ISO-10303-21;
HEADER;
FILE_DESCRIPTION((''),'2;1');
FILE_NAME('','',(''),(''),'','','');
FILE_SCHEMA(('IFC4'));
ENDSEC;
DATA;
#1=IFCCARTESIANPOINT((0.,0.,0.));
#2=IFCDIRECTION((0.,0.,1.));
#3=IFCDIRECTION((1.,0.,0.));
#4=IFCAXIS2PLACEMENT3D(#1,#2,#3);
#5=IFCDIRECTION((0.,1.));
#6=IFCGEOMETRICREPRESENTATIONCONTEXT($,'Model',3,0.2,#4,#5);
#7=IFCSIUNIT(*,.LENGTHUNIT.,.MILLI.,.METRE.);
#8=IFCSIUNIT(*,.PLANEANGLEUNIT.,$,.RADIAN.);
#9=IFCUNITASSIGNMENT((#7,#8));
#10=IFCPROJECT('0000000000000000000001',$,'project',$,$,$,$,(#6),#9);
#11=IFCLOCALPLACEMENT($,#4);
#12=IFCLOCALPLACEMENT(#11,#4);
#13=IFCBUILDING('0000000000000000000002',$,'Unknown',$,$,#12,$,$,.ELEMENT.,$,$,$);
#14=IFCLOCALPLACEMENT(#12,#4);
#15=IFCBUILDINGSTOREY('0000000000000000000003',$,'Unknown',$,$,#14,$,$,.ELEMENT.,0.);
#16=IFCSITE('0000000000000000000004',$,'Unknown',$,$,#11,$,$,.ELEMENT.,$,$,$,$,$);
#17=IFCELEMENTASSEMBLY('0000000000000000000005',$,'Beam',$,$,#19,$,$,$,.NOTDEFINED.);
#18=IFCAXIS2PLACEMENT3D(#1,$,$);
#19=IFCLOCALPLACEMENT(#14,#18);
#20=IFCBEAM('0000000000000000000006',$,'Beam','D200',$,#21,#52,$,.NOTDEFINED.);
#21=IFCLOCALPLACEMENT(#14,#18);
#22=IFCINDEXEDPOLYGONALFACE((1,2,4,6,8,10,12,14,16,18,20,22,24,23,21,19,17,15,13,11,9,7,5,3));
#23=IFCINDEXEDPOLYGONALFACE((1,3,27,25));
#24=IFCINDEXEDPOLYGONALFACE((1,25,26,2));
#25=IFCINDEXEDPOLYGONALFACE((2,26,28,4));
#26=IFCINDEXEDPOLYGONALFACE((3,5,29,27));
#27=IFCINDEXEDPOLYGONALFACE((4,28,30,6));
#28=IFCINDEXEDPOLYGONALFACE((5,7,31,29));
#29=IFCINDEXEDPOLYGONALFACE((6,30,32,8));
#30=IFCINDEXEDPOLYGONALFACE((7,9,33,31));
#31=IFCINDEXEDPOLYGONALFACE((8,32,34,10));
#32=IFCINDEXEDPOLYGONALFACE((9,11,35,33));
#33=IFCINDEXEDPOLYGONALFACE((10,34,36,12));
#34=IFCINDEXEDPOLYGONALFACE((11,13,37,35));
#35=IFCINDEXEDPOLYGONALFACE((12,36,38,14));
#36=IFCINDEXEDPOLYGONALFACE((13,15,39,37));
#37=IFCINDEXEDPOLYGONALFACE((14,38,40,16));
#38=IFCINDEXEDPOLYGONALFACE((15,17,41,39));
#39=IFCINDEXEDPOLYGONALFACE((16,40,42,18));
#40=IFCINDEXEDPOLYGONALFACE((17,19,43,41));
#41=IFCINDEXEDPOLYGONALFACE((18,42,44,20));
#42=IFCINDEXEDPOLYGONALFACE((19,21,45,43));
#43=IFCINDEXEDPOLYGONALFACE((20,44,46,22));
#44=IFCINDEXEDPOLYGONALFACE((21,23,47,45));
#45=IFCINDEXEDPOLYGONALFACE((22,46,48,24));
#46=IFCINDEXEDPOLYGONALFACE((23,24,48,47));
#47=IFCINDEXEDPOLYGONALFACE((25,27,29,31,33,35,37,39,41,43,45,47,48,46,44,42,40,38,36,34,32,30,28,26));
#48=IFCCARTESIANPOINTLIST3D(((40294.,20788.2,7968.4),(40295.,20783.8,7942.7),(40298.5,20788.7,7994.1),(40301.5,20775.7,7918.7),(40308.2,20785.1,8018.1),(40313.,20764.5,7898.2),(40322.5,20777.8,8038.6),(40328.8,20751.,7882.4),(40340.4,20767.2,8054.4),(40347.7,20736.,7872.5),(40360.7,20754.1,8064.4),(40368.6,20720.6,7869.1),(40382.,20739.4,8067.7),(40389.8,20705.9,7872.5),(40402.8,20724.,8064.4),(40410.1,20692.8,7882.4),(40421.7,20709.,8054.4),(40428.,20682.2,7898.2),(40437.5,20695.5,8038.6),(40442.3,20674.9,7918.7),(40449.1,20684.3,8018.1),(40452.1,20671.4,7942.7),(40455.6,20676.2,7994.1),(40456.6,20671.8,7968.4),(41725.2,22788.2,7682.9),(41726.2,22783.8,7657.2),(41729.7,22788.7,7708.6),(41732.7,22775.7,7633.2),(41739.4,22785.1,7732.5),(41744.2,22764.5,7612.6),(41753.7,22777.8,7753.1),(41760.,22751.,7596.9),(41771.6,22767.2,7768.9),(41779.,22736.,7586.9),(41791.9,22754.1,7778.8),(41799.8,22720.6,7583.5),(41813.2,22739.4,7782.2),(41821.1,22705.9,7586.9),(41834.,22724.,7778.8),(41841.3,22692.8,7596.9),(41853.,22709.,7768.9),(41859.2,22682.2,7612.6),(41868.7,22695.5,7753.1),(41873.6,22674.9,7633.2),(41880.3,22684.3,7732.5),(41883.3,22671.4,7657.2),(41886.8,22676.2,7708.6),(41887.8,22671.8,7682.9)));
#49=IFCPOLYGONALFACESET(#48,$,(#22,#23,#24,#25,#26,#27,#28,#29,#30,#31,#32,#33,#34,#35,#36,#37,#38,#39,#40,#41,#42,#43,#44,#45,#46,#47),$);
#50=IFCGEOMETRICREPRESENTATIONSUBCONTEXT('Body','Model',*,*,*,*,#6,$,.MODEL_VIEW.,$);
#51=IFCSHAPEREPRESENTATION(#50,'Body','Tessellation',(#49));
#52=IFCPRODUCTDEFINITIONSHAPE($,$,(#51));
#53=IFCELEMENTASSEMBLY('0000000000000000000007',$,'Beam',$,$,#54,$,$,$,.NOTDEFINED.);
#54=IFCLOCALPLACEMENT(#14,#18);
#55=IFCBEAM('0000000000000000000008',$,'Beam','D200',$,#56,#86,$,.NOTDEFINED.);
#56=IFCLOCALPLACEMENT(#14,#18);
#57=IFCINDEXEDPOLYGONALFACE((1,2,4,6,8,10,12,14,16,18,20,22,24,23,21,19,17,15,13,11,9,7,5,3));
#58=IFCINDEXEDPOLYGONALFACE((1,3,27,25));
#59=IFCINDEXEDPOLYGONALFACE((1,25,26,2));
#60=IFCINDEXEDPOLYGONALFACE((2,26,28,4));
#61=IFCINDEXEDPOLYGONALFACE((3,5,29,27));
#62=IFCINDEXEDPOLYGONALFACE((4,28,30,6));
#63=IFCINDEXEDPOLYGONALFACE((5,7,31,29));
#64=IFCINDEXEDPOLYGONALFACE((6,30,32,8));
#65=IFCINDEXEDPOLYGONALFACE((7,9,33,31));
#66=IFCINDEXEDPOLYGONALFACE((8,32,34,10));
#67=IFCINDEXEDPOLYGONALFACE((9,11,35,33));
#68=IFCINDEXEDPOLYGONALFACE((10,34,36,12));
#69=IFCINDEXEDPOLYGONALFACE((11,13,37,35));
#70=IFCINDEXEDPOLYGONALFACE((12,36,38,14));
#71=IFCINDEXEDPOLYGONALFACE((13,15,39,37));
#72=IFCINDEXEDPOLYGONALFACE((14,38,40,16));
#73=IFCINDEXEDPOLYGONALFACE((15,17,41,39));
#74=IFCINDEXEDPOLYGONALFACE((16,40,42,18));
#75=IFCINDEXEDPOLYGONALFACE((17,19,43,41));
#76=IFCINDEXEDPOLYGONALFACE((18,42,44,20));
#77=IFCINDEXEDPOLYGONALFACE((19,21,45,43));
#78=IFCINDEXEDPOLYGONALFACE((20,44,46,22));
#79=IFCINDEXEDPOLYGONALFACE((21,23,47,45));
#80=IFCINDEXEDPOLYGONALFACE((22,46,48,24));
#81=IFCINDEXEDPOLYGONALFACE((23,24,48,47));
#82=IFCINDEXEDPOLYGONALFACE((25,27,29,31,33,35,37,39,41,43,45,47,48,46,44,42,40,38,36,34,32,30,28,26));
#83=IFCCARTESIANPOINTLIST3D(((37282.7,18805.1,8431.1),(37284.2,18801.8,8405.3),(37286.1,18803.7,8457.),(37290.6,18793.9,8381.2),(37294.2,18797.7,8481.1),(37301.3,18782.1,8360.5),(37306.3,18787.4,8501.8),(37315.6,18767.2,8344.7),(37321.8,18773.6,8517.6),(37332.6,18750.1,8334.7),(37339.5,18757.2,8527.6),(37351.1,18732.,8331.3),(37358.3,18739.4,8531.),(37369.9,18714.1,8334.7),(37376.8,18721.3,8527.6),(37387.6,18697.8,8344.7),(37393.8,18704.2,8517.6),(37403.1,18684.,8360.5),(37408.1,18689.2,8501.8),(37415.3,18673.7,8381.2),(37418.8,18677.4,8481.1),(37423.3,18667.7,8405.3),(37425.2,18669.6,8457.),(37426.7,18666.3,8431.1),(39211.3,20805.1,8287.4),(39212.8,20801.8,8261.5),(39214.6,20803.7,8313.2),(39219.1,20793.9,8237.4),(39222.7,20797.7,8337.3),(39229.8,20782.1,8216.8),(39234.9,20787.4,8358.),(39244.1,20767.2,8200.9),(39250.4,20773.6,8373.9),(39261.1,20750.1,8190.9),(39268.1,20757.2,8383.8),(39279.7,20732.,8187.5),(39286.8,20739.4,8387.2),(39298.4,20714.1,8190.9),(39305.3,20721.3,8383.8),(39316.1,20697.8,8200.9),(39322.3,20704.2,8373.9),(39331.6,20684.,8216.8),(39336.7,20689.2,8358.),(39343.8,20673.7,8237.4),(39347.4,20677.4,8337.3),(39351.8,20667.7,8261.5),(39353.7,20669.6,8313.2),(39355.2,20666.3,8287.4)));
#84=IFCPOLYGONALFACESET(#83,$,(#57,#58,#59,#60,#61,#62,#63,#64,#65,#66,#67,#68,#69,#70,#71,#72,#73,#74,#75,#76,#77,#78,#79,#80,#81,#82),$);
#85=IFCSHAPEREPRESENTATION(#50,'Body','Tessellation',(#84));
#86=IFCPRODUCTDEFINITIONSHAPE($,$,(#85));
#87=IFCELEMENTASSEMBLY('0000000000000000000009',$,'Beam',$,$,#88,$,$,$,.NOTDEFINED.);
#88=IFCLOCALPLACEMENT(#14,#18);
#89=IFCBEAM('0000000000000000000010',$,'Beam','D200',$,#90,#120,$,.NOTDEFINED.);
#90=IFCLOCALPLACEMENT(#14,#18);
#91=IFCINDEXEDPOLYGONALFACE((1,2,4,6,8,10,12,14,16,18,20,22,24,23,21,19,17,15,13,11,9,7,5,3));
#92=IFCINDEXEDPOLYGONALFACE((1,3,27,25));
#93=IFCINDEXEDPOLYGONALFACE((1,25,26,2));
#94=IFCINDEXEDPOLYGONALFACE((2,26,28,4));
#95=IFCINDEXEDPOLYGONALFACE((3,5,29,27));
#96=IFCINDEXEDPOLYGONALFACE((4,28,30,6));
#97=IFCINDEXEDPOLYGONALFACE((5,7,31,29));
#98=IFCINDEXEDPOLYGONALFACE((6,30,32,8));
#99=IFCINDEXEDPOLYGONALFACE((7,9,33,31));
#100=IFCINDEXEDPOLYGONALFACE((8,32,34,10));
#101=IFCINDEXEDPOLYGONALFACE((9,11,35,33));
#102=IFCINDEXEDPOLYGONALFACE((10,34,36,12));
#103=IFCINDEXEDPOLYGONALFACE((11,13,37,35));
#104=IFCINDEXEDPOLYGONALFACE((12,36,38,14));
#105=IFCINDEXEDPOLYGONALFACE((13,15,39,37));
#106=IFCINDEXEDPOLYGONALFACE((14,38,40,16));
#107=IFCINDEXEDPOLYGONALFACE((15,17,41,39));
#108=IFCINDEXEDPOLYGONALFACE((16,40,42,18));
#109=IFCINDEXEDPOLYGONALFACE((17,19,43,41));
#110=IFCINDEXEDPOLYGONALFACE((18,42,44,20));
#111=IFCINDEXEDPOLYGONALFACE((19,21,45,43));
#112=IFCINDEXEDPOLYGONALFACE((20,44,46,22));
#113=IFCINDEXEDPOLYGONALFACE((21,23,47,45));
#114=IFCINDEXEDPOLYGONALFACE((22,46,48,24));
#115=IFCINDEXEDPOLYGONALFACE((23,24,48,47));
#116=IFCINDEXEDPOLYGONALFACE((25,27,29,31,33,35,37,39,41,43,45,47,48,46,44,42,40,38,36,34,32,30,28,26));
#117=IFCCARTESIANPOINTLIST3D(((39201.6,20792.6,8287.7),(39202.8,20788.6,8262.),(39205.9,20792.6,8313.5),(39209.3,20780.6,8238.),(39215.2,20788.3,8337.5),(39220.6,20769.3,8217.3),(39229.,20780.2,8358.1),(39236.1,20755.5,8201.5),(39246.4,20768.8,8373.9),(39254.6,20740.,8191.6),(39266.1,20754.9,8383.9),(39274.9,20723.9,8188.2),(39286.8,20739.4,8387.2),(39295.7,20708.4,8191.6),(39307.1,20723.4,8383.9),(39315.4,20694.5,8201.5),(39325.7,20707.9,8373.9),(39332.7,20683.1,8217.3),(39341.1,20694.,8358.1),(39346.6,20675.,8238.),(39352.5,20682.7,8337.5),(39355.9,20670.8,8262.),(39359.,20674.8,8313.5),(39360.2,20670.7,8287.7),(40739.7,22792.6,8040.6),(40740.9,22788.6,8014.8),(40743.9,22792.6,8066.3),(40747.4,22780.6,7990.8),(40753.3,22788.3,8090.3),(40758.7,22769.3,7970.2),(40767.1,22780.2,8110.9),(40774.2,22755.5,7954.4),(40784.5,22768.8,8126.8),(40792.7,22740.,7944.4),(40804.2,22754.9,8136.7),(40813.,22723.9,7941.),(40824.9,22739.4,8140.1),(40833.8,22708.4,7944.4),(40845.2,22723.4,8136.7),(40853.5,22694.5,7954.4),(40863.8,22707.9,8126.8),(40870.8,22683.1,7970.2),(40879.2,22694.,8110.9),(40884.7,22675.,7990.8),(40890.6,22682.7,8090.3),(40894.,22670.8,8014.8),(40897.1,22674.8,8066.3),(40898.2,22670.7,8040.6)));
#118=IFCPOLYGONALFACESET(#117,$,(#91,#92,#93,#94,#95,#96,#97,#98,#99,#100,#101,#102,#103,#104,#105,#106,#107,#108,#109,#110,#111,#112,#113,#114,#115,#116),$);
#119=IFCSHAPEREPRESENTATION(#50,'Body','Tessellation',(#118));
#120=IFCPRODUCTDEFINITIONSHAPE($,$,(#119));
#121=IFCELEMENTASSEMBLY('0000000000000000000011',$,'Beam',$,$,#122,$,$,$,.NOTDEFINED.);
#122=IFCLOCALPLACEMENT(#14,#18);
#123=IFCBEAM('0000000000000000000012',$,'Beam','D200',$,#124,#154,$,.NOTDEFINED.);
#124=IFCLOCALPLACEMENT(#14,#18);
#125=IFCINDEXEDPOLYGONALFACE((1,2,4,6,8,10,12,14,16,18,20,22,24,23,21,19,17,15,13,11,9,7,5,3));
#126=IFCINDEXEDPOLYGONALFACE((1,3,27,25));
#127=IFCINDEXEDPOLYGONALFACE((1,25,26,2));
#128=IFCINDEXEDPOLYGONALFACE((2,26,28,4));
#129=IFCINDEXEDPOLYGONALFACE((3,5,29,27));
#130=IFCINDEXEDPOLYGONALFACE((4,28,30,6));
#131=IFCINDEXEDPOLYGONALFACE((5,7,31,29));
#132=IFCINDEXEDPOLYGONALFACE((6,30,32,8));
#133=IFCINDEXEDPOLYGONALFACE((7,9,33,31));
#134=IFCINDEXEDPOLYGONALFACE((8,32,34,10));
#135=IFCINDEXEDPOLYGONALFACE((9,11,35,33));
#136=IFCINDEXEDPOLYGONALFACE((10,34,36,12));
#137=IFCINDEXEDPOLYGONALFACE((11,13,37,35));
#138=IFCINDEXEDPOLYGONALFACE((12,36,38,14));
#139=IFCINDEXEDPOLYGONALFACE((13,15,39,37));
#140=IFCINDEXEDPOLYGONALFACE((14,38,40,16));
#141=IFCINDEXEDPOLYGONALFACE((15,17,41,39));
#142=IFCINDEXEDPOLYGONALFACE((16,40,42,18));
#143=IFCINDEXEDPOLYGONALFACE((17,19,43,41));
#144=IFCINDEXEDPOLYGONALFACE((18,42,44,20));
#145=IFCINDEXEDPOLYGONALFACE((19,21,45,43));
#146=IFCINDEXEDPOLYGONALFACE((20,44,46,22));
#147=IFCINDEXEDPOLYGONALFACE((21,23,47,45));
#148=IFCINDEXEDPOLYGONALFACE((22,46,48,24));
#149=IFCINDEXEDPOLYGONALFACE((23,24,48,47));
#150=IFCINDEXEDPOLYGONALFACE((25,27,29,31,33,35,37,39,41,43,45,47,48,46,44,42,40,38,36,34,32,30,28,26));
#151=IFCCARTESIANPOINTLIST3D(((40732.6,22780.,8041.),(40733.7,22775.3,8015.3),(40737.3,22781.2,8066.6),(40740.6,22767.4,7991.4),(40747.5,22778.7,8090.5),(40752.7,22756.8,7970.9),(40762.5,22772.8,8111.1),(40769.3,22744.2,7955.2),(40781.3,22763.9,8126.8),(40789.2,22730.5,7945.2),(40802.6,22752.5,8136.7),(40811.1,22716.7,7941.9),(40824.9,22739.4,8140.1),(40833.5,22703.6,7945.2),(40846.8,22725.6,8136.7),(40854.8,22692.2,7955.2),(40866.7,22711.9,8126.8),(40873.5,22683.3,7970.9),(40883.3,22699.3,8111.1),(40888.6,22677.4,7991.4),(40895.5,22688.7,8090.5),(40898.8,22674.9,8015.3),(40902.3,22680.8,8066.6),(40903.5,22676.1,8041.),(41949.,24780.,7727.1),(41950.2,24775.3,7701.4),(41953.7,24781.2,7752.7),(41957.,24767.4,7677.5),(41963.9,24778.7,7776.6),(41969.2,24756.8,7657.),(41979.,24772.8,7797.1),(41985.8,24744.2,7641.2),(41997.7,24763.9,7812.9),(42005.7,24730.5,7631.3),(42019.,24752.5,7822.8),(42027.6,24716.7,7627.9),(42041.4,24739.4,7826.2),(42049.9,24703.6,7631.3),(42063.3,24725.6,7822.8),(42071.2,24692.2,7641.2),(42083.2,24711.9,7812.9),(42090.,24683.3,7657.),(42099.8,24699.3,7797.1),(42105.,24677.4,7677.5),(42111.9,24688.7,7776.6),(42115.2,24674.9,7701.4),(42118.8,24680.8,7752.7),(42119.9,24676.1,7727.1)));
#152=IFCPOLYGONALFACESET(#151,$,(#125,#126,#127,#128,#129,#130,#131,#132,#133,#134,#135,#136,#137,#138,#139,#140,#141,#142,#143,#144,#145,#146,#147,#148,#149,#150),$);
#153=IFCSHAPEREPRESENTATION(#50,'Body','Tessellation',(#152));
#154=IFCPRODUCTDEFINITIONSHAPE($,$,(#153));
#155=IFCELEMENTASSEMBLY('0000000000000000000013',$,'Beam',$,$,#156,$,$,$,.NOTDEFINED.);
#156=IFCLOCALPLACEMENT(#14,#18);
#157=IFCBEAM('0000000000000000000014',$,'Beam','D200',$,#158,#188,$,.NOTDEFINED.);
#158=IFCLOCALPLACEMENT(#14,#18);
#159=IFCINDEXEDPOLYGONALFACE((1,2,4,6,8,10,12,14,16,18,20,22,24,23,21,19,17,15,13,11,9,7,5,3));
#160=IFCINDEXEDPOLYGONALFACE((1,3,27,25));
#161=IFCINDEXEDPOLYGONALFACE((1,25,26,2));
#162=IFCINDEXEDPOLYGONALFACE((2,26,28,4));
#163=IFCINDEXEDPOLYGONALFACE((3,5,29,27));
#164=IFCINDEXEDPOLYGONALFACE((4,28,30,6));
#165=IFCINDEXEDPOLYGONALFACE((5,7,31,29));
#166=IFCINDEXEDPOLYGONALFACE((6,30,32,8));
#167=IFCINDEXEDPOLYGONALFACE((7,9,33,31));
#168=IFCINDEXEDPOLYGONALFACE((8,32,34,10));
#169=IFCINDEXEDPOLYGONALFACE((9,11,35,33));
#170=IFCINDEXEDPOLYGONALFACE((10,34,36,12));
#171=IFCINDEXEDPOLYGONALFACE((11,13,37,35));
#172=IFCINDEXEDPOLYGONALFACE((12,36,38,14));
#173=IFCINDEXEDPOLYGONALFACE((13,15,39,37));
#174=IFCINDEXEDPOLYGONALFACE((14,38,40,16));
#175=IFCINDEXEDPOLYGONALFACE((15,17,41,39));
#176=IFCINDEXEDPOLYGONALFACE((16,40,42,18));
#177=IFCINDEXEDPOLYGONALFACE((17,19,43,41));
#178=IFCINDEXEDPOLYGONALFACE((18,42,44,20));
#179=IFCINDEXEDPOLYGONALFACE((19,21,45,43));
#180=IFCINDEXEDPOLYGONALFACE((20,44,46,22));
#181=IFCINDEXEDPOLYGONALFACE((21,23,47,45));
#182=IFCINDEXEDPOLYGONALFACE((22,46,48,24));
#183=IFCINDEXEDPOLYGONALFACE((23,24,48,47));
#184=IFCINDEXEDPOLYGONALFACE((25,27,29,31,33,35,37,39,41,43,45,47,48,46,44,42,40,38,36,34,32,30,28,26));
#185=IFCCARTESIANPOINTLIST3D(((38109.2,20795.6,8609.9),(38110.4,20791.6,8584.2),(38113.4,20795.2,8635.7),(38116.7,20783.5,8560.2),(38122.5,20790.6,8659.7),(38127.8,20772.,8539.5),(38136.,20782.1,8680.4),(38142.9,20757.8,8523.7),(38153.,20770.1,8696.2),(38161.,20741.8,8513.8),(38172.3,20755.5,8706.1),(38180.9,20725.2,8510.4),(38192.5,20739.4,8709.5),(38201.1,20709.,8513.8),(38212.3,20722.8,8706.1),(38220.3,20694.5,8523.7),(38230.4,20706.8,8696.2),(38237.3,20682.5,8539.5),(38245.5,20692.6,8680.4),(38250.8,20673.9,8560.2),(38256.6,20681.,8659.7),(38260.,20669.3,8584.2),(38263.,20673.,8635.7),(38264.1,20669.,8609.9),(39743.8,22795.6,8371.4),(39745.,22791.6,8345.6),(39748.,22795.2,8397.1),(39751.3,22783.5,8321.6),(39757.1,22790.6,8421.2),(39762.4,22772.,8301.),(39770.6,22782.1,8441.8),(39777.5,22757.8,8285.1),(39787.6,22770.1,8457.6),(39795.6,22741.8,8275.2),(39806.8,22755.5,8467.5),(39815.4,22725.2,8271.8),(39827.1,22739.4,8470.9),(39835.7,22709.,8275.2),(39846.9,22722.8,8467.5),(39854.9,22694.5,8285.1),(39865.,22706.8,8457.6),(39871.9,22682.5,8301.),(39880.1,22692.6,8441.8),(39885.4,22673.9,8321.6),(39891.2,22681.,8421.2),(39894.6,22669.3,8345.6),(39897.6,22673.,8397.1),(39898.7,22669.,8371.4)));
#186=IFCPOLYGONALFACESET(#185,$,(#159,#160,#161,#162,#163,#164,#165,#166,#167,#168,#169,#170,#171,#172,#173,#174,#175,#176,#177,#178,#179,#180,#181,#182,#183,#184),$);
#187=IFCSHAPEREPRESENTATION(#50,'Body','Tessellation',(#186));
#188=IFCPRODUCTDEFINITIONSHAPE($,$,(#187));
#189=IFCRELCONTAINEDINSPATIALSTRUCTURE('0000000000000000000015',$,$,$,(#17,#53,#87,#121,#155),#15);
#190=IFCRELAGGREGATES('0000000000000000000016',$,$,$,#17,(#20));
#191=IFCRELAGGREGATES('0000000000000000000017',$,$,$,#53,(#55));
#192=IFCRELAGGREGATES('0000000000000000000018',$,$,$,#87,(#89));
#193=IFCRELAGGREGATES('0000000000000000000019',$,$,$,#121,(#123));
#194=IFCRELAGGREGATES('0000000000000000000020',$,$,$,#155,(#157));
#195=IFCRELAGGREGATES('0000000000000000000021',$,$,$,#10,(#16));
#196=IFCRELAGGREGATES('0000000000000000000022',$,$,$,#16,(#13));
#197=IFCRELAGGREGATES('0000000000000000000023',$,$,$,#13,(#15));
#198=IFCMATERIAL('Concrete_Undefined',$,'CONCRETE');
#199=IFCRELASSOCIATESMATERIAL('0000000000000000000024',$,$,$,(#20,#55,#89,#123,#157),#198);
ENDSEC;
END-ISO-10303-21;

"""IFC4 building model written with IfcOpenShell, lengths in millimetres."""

from ifc_helpers import new_model, si_unit, direction, frame, origin_with_axes, place, context, subcontext, project, spatial, line, indexed_curve, outline, extrude, material, element, aggregate, save


model = new_model("IFC4")

# Units and contexts
model_context = context("Model", 3, precision=0.2, world=origin_with_axes(), true_north=direction((0.0, 1.0)))
body_context = subcontext(model_context, "Body", "Model", "MODEL_VIEW")
ifc_project = project(units=[si_unit("LENGTHUNIT", "METRE", prefix="MILLI"), si_unit("PLANEANGLEUNIT", "RADIAN")], contexts=[model_context])

# Site, building, storey
site_placement = place(None, origin_with_axes())
site = spatial("IfcSite", under=ifc_project, at=site_placement, Name="Unknown", CompositionType="ELEMENT")
building_placement = place(site_placement, origin_with_axes())
building = spatial("IfcBuilding", under=site, at=building_placement, Name="Unknown", CompositionType="ELEMENT")
storey_placement = place(building_placement, origin_with_axes())
storey = spatial("IfcBuildingStorey", under=building, at=storey_placement, Name="Unknown", CompositionType="ELEMENT", Elevation=0.0)

# Element assemblies, beams
ifc_material = material(Name="Concrete_Undefined", Category="CONCRETE")
assembly_1_placement = place(storey_placement, frame((41806.5, 22730.0, 7682.9), z_axis=(-0.813224, 0.58195, 0.0), x_axis=(-0.578067, -0.807799, 0.115323)))
assembly_1 = element("IfcElementAssembly", 1, at=assembly_1_placement, inside=storey, Name="Beam", PredefinedType="NOTDEFINED")
beam_1_placement = place(assembly_1_placement, origin_with_axes())
beam_1 = element("IfcBeam", 2, at=beam_1_placement, material=ifc_material, Name="Beam", Description="D200", PredefinedType="NOTDEFINED", context=body_context, shape_type="SolidModel", body=[
    extrude(outline(indexed_curve([(100.0, 0.0), (96.6, 25.9), (86.6, 50.0), (70.7, 70.7), (50.0, 86.6), (25.9, 96.6), (0.0, 100.0), (-25.9, 96.6), (-50.0, 86.6), (-70.7, 70.7), (-86.6, 50.0), (-96.6, 25.9), (-100.0, 0.0), (-96.6, -25.9), (-86.6, -50.0), (-70.7, -70.7), (-50.0, -86.6), (-25.9, -96.6), (0.0, -100.0), (25.9, -96.6), (50.0, -86.6), (70.7, -70.7), (86.6, -50.0), (96.6, -25.9)], segments=[line(1, 2, 3, 4, 5, 6, 7, 8, 9, 10, 11, 12, 13, 14, 15, 16, 17, 18, 19, 20, 21, 22, 23, 24, 1)])), frame((0.0, 0.0, 0.0), z_axis=(-1.0, 0.0, 0.0), x_axis=(0.0, 0.0, 1.0)), (0.0, 0.0, -1.0), 2475.9),
])
aggregate(assembly_1, [beam_1])
assembly_2_placement = place(storey_placement, frame((39283.2, 20735.7, 8287.4), z_axis=(-0.719851, 0.694129, 0.0), x_axis=(-0.693202, -0.718889, 0.051675)))
assembly_2 = element("IfcElementAssembly", 3, at=assembly_2_placement, inside=storey, Name="Beam", PredefinedType="NOTDEFINED")
beam_2_placement = place(assembly_2_placement, origin_with_axes())
beam_2 = element("IfcBeam", 4, at=beam_2_placement, material=ifc_material, Name="Beam", Description="D200", PredefinedType="NOTDEFINED", context=body_context, shape_type="SolidModel", body=[
    extrude(outline(indexed_curve([(100.0, 0.0), (96.6, 25.9), (86.6, 50.0), (70.7, 70.7), (50.0, 86.6), (25.9, 96.6), (0.0, 100.0), (-25.9, 96.6), (-50.0, 86.6), (-70.7, 70.7), (-86.6, 50.0), (-96.6, 25.9), (-100.0, 0.0), (-96.6, -25.9), (-86.6, -50.0), (-70.7, -70.7), (-50.0, -86.6), (-25.9, -96.6), (0.0, -100.0), (25.9, -96.6), (50.0, -86.6), (70.7, -70.7), (86.6, -50.0), (96.6, -25.9)], segments=[line(1, 2, 3, 4, 5, 6, 7, 8, 9, 10, 11, 12, 13, 14, 15, 16, 17, 18, 19, 20, 21, 22, 23, 24, 1)])), frame((0.0, 0.0, 0.0), z_axis=(-1.0, 0.0, 0.0), x_axis=(0.0, 0.0, 1.0)), (0.0, 0.0, -1.0), 2782.1),
])
aggregate(assembly_2, [beam_2])
assembly_3_placement = place(storey_placement, frame((40819.0, 22731.7, 8040.6), z_axis=(-0.792695, 0.609618, 0.0), x_axis=(-0.606714, -0.788919, 0.097489)))
assembly_3 = element("IfcElementAssembly", 5, at=assembly_3_placement, inside=storey, Name="Beam", PredefinedType="NOTDEFINED")
beam_3_placement = place(assembly_3_placement, origin_with_axes())
beam_3 = element("IfcBeam", 6, at=beam_3_placement, material=ifc_material, Name="Beam", Description="D200", PredefinedType="NOTDEFINED", context=body_context, shape_type="SolidModel", body=[
    extrude(outline(indexed_curve([(100.0, 0.0), (96.6, 25.9), (86.6, 50.0), (70.7, 70.7), (50.0, 86.6), (25.9, 96.6), (0.0, 100.0), (-25.9, 96.6), (-50.0, 86.6), (-70.7, 70.7), (-86.6, 50.0), (-96.6, 25.9), (-100.0, 0.0), (-96.6, -25.9), (-86.6, -50.0), (-70.7, -70.7), (-50.0, -86.6), (-25.9, -96.6), (0.0, -100.0), (25.9, -96.6), (50.0, -86.6), (70.7, -70.7), (86.6, -50.0), (96.6, -25.9)], segments=[line(1, 2, 3, 4, 5, 6, 7, 8, 9, 10, 11, 12, 13, 14, 15, 16, 17, 18, 19, 20, 21, 22, 23, 24, 1)])), frame((0.0, 0.0, 0.0), z_axis=(-1.0, 0.0, 0.0), x_axis=(0.0, 0.0, 1.0)), (0.0, 0.0, -1.0), 2535.1),
])
aggregate(assembly_3, [beam_3])
assembly_4_placement = place(storey_placement, frame((42034.5, 24728.0, 7727.1), z_axis=(-0.854373, 0.51966, 0.0), x_axis=(-0.515049, -0.846793, 0.132915)))
assembly_4 = element("IfcElementAssembly", 7, at=assembly_4_placement, inside=storey, Name="Beam", PredefinedType="NOTDEFINED")
beam_4_placement = place(assembly_4_placement, origin_with_axes())
beam_4 = element("IfcBeam", 8, at=beam_4_placement, material=ifc_material, Name="Beam", Description="D200", PredefinedType="NOTDEFINED", context=body_context, shape_type="SolidModel", body=[
    extrude(outline(indexed_curve([(100.0, 0.0), (96.6, 25.9), (86.6, 50.0), (70.7, 70.7), (50.0, 86.6), (25.9, 96.6), (0.0, 100.0), (-25.9, 96.6), (-50.0, 86.6), (-70.7, 70.7), (-86.6, 50.0), (-96.6, 25.9), (-100.0, 0.0), (-96.6, -25.9), (-86.6, -50.0), (-70.7, -70.7), (-50.0, -86.6), (-25.9, -96.6), (0.0, -100.0), (25.9, -96.6), (50.0, -86.6), (70.7, -70.7), (86.6, -50.0), (96.6, -25.9)], segments=[line(1, 2, 3, 4, 5, 6, 7, 8, 9, 10, 11, 12, 13, 14, 15, 16, 17, 18, 19, 20, 21, 22, 23, 24, 1)])), frame((0.0, 0.0, 0.0), z_axis=(-1.0, 0.0, 0.0), x_axis=(0.0, 0.0, 1.0)), (0.0, 0.0, -1.0), 2361.9),
])
aggregate(assembly_4, [beam_4])
assembly_5_placement = place(storey_placement, frame((39821.3, 22732.3, 8371.4), z_axis=(-0.774293, 0.632827, 0.0), x_axis=(-0.630145, -0.771011, 0.091973)))
assembly_5 = element("IfcElementAssembly", 9, at=assembly_5_placement, inside=storey, Name="Beam", PredefinedType="NOTDEFINED")
beam_5_placement = place(assembly_5_placement, origin_with_axes())
beam_5 = element("IfcBeam", 10, at=beam_5_placement, material=ifc_material, Name="Beam", Description="D200", PredefinedType="NOTDEFINED", context=body_context, shape_type="SolidModel", body=[
    extrude(outline(indexed_curve([(100.0, 0.0), (96.6, 25.9), (86.6, 50.0), (70.7, 70.7), (50.0, 86.6), (25.9, 96.6), (0.0, 100.0), (-25.9, 96.6), (-50.0, 86.6), (-70.7, 70.7), (-86.6, 50.0), (-96.6, 25.9), (-100.0, 0.0), (-96.6, -25.9), (-86.6, -50.0), (-70.7, -70.7), (-50.0, -86.6), (-25.9, -96.6), (0.0, -100.0), (25.9, -96.6), (50.0, -86.6), (70.7, -70.7), (86.6, -50.0), (96.6, -25.9)], segments=[line(1, 2, 3, 4, 5, 6, 7, 8, 9, 10, 11, 12, 13, 14, 15, 16, 17, 18, 19, 20, 21, 22, 23, 24, 1)])), frame((0.0, 0.0, 0.0), z_axis=(-1.0, 0.0, 0.0), x_axis=(0.0, 0.0, 1.0)), (0.0, 0.0, -1.0), 2594.0),
])
aggregate(assembly_5, [beam_5])

save(model, "model.ifc")
